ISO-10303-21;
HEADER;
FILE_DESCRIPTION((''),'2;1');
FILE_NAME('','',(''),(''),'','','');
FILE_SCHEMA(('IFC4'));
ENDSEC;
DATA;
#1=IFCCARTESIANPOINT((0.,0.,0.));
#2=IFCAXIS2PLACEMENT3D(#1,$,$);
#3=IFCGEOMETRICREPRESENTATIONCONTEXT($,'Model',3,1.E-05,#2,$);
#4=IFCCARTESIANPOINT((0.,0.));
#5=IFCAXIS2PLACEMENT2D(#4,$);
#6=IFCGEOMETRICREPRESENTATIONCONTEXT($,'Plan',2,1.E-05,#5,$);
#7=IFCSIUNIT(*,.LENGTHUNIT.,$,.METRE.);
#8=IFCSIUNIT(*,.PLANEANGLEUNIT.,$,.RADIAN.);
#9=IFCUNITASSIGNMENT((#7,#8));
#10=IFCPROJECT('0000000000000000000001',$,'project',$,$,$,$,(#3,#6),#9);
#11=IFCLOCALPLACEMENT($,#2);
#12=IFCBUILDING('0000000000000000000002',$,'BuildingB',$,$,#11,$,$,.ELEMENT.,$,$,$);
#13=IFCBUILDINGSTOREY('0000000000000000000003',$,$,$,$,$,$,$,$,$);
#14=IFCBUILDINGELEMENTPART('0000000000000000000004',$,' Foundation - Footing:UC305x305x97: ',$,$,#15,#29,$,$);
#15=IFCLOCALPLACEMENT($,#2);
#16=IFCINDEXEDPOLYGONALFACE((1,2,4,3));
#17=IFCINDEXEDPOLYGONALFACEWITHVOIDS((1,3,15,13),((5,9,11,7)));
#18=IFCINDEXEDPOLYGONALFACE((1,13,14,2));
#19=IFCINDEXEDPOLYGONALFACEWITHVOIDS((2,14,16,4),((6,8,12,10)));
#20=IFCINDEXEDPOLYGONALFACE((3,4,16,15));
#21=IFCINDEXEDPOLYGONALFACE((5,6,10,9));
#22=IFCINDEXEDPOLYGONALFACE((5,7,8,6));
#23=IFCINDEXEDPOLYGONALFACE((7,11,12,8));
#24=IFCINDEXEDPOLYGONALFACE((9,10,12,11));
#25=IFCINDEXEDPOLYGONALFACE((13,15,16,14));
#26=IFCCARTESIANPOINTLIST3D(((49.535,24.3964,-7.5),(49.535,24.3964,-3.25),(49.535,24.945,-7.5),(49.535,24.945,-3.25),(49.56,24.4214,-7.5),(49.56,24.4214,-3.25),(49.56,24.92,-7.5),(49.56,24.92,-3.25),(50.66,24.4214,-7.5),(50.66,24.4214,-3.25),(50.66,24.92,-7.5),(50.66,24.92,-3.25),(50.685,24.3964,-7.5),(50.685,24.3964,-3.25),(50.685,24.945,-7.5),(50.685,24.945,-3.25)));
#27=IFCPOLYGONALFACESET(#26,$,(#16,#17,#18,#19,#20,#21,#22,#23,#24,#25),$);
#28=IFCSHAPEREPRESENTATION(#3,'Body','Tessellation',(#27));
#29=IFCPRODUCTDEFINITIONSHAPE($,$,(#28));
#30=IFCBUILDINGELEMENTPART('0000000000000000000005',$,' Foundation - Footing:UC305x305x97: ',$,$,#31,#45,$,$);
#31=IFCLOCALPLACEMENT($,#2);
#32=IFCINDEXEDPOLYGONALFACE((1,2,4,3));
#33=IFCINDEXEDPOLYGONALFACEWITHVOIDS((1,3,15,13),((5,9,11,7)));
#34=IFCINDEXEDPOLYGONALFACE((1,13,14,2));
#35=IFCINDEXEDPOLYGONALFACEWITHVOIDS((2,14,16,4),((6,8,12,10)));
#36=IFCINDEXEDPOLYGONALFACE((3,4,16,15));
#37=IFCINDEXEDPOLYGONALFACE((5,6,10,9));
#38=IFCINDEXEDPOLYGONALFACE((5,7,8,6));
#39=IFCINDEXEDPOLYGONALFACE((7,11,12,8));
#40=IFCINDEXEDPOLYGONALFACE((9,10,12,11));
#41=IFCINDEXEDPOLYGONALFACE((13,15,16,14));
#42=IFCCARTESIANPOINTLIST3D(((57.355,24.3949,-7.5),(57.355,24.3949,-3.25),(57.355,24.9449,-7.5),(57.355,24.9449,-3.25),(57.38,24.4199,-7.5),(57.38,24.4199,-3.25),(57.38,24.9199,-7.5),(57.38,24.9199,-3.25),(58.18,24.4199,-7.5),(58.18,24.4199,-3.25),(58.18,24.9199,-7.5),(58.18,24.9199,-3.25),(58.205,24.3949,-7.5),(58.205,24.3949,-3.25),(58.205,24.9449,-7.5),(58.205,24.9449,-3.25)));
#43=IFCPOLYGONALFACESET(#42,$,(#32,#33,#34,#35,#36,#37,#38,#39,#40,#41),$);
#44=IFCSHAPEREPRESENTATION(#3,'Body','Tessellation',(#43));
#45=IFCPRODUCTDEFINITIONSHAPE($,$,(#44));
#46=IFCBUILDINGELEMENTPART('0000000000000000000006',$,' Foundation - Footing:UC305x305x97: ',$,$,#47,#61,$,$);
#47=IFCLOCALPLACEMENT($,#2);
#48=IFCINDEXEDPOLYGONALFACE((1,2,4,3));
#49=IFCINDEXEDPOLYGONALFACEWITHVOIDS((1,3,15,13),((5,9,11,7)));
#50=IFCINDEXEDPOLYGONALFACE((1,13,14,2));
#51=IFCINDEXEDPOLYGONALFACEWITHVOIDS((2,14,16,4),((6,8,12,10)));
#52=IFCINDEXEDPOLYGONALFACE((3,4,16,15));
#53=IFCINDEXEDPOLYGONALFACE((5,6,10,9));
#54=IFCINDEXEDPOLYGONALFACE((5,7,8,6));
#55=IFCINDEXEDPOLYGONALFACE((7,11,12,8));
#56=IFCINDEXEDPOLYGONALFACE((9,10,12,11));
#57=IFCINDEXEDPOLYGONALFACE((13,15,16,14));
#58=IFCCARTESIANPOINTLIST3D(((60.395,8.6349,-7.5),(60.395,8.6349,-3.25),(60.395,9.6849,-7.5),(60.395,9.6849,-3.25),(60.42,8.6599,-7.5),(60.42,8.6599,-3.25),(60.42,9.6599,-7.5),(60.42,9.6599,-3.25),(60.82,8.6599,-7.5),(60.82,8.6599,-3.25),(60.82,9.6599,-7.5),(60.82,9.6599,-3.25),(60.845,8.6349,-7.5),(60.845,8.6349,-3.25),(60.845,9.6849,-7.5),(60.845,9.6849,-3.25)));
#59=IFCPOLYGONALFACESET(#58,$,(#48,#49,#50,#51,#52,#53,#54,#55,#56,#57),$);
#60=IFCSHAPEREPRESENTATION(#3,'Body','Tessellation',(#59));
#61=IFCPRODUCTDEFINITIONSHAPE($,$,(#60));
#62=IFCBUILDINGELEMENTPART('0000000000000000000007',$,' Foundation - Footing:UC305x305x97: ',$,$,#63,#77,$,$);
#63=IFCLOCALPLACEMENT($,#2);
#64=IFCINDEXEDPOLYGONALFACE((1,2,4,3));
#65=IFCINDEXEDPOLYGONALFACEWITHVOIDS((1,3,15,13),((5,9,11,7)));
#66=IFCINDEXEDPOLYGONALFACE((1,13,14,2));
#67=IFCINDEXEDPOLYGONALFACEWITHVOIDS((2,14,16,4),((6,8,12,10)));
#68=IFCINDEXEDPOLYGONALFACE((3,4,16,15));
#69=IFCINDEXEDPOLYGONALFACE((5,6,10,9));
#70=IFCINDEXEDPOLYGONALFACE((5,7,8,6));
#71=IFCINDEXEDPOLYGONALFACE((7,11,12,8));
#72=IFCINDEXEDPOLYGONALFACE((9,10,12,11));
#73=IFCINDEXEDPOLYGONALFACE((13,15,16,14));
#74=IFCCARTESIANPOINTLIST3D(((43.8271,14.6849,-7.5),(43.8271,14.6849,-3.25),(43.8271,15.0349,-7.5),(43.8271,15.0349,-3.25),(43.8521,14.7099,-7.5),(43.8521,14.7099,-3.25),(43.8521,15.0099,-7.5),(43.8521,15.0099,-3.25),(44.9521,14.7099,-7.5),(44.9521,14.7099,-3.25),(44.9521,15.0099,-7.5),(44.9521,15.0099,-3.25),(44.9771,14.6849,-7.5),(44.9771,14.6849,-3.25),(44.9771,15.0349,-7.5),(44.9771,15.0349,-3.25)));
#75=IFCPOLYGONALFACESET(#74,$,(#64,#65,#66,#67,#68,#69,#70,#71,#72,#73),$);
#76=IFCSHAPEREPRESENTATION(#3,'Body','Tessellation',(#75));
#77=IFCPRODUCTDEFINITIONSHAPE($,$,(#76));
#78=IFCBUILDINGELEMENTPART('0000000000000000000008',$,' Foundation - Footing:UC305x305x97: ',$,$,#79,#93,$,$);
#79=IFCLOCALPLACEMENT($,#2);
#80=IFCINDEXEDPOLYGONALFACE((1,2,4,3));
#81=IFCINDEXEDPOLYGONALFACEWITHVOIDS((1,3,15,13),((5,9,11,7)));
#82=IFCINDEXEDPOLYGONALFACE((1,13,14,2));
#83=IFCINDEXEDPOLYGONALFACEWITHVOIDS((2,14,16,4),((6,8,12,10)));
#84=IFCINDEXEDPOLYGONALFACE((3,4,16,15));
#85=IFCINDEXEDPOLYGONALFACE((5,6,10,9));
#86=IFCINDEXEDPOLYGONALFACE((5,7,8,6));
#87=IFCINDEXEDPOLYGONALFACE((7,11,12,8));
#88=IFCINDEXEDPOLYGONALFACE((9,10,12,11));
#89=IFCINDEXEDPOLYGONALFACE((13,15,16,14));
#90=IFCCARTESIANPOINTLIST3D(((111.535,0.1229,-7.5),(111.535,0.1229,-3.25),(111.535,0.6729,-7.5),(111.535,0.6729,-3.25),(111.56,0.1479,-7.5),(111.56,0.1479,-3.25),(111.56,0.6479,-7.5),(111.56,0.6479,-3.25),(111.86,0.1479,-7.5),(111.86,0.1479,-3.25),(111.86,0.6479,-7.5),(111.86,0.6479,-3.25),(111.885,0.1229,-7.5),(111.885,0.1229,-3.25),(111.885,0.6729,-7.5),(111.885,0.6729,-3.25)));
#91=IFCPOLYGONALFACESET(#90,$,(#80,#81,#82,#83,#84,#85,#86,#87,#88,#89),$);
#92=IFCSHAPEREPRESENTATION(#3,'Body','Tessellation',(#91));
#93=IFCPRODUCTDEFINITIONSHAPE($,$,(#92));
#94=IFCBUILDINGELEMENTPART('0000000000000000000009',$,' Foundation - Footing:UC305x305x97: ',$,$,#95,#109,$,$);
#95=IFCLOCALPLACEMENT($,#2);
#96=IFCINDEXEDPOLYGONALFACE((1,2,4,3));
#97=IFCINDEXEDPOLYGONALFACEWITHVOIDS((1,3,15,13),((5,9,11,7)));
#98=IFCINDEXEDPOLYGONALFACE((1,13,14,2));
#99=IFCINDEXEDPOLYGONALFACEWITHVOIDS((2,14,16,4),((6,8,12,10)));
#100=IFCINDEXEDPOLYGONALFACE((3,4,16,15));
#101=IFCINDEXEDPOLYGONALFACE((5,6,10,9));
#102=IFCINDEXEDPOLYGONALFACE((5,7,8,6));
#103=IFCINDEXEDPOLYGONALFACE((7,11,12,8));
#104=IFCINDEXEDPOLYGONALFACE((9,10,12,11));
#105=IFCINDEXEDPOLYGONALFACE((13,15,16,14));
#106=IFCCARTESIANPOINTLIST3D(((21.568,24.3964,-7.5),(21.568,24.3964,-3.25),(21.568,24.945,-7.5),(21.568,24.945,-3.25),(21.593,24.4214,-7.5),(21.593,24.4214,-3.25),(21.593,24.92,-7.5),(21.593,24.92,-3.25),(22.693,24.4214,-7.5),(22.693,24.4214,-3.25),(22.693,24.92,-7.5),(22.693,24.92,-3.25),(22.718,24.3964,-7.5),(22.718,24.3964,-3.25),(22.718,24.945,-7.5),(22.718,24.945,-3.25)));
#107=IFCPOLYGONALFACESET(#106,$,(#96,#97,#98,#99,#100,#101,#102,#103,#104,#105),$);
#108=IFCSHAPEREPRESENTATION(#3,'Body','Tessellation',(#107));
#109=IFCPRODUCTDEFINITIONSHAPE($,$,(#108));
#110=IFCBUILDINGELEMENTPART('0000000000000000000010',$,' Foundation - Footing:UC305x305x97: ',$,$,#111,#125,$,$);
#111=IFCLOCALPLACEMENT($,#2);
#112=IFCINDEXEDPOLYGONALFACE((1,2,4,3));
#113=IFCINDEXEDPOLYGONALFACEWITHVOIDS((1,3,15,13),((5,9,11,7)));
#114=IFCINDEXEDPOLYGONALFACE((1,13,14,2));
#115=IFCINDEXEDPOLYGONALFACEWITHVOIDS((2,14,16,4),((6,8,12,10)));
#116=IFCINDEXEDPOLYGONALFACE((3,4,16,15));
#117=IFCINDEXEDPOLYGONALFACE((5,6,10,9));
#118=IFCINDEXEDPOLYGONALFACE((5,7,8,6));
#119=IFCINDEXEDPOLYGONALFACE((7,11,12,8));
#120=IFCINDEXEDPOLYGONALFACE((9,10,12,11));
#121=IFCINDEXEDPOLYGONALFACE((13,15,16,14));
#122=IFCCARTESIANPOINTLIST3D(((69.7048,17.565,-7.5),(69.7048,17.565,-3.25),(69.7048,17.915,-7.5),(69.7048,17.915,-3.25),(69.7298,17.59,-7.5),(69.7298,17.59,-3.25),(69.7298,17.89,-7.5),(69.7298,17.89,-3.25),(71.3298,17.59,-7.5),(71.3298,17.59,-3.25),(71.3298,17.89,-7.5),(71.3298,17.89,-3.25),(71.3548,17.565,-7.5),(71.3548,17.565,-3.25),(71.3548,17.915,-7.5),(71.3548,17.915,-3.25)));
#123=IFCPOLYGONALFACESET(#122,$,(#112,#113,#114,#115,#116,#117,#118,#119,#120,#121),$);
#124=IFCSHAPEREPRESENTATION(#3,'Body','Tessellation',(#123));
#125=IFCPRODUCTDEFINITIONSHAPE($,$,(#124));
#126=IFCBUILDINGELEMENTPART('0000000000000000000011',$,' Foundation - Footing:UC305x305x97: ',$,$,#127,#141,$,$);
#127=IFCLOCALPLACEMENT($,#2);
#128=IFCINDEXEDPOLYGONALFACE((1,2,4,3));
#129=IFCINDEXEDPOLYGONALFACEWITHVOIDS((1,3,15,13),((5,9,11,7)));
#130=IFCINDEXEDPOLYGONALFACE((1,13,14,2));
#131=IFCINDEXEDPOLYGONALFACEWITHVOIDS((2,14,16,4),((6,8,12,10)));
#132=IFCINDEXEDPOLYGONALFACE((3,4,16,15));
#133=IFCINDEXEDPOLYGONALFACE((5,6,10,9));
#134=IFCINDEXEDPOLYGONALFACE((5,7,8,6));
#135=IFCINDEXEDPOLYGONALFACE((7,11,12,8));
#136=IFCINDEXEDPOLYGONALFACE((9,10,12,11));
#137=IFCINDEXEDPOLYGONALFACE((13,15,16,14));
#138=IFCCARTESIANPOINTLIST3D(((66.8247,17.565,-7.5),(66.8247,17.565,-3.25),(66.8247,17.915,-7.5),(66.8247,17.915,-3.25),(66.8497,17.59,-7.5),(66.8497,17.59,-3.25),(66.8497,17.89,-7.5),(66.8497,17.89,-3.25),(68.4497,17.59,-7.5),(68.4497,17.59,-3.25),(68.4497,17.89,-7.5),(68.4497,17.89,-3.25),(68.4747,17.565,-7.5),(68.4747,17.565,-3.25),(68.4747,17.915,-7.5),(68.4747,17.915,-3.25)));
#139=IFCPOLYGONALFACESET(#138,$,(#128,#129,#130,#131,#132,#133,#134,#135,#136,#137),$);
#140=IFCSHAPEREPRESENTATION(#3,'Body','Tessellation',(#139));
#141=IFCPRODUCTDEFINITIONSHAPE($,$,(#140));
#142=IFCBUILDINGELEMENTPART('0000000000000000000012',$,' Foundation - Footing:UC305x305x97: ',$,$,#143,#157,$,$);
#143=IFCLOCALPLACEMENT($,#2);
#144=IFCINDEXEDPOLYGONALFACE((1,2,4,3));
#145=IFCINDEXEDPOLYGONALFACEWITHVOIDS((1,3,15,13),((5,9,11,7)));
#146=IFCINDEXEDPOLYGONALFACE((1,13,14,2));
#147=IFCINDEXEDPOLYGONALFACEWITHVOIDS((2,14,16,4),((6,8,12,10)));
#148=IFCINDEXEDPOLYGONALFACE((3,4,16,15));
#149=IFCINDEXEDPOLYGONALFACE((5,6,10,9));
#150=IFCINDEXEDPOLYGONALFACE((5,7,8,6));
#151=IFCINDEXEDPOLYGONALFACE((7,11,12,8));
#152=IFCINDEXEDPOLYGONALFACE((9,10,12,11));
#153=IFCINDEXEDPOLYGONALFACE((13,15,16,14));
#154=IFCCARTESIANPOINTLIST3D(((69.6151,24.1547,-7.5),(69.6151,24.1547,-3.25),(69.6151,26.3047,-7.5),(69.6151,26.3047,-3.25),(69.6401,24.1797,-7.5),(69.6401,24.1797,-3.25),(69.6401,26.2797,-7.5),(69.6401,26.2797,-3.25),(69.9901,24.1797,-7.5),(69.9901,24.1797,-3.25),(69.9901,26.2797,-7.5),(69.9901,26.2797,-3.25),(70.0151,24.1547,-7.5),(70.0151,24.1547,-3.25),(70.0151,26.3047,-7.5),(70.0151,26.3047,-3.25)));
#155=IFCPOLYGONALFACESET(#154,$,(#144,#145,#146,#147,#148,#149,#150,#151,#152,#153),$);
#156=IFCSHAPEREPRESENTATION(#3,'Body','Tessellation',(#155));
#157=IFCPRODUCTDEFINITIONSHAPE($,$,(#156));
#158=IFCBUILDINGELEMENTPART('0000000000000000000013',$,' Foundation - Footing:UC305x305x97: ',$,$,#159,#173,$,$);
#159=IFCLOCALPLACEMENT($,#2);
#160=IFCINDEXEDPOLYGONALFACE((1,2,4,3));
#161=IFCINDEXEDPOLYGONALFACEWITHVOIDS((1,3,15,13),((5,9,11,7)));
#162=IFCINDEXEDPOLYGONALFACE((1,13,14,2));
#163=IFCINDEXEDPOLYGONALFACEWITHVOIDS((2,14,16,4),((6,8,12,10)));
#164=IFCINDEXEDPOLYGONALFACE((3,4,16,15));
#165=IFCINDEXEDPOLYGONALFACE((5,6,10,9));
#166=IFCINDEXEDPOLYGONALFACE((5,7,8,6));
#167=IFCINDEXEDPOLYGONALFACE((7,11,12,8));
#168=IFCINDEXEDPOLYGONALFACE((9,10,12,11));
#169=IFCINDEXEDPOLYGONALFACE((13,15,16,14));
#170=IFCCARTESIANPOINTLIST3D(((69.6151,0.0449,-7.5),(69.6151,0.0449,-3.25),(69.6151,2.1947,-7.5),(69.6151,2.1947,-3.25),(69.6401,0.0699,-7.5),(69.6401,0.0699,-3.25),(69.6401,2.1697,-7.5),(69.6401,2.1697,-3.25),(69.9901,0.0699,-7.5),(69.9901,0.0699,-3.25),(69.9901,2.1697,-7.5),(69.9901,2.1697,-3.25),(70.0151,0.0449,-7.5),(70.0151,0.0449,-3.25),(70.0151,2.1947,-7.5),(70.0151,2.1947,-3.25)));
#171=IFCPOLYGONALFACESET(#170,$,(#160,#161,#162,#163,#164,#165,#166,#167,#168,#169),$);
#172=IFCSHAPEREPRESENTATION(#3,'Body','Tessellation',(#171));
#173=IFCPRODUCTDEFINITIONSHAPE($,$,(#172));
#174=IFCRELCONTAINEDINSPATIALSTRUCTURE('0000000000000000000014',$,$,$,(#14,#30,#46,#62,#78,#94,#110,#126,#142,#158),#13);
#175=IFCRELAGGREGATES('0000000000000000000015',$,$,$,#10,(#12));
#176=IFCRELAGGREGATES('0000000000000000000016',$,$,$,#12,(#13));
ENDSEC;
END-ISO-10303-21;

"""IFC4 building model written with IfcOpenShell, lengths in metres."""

from ifc_helpers import new_model, si_unit, origin, origin_2d, place, context, project, spatial, polyline, outline, extrude, element, save


model = new_model("IFC4")

# Units and contexts
model_context = context("Model", 3, precision=1e-05, world=origin())
plan_context = context("Plan", 2, precision=1e-05, world=origin_2d())
ifc_project = project(units=[si_unit("LENGTHUNIT", "METRE"), si_unit("PLANEANGLEUNIT", "RADIAN")], contexts=[model_context, plan_context])

# Building, storey
building_placement = place(None, origin())
building = spatial("IfcBuilding", under=ifc_project, at=building_placement, Name="BuildingB", CompositionType="ELEMENT")
storey = spatial("IfcBuildingStorey", under=building)

# Building element parts, openings
building_element_part_1 = element("IfcBuildingElementPart", 1, inside=storey, Name=" Foundation - Footing:UC305x305x97: ", context=model_context, shape_type="SweptSolid", body=[
    extrude(outline(polyline([(50.685, 24.3964, -7.5), (49.535, 24.3964, -7.5), (49.535, 24.945, -7.5), (50.685, 24.945, -7.5), (50.685, 24.3964, -7.5)])), None, (0.0, 0.0, 1.0), 4.25),
])
element("IfcOpeningElement", 2, inside=storey, cuts=building_element_part_1, context=model_context, shape_type="SweptSolid", body=[
    extrude(outline(polyline([(50.66, 24.4214, -7.5), (49.56, 24.4214, -7.5), (49.56, 24.92, -7.5), (50.66, 24.92, -7.5), (50.66, 24.4214, -7.5)])), None, (0.0, 0.0, 1.0), 4.25),
])
building_element_part_2 = element("IfcBuildingElementPart", 3, inside=storey, Name=" Foundation - Footing:UC305x305x97: ", context=model_context, shape_type="SweptSolid", body=[
    extrude(outline(polyline([(57.355, 24.3949, -7.5), (58.205, 24.3949, -7.5), (58.205, 24.9449, -7.5), (57.355, 24.9449, -7.5), (57.355, 24.3949, -7.5)])), None, (0.0, 0.0, 1.0), 4.25),
])
element("IfcOpeningElement", 4, inside=storey, cuts=building_element_part_2, context=model_context, shape_type="SweptSolid", body=[
    extrude(outline(polyline([(57.38, 24.4199, -7.5), (58.18, 24.4199, -7.5), (58.18, 24.9199, -7.5), (57.38, 24.9199, -7.5), (57.38, 24.4199, -7.5)])), None, (0.0, 0.0, 1.0), 4.25),
])
building_element_part_3 = element("IfcBuildingElementPart", 5, inside=storey, Name=" Foundation - Footing:UC305x305x97: ", context=model_context, shape_type="SweptSolid", body=[
    extrude(outline(polyline([(60.395, 8.6349, -7.5), (60.845, 8.6349, -7.5), (60.845, 9.6849, -7.5), (60.395, 9.6849, -7.5), (60.395, 8.6349, -7.5)])), None, (0.0, 0.0, 1.0), 4.25),
])
element("IfcOpeningElement", 6, inside=storey, cuts=building_element_part_3, context=model_context, shape_type="SweptSolid", body=[
    extrude(outline(polyline([(60.42, 8.6599, -7.5), (60.82, 8.6599, -7.5), (60.82, 9.6599, -7.5), (60.42, 9.6599, -7.5), (60.42, 8.6599, -7.5)])), None, (0.0, 0.0, 1.0), 4.25),
])
building_element_part_4 = element("IfcBuildingElementPart", 7, inside=storey, Name=" Foundation - Footing:UC305x305x97: ", context=model_context, shape_type="SweptSolid", body=[
    extrude(outline(polyline([(44.9771, 14.6849, -7.5), (44.9771, 15.0349, -7.5), (43.8271, 15.0349, -7.5), (43.8271, 14.6849, -7.5), (44.9771, 14.6849, -7.5)])), None, (0.0, 0.0, 1.0), 4.25),
])
element("IfcOpeningElement", 8, inside=storey, cuts=building_element_part_4, context=model_context, shape_type="SweptSolid", body=[
    extrude(outline(polyline([(44.9521, 14.7099, -7.5), (44.9521, 15.0099, -7.5), (43.8521, 15.0099, -7.5), (43.8521, 14.7099, -7.5), (44.9521, 14.7099, -7.5)])), None, (0.0, 0.0, 1.0), 4.25),
])
building_element_part_5 = element("IfcBuildingElementPart", 9, inside=storey, Name=" Foundation - Footing:UC305x305x97: ", context=model_context, shape_type="SweptSolid", body=[
    extrude(outline(polyline([(111.535, 0.6729, -7.5), (111.885, 0.6729, -7.5), (111.885, 0.1229, -7.5), (111.535, 0.1229, -7.5), (111.535, 0.6729, -7.5)])), None, (0.0, 0.0, 1.0), 4.25),
])
element("IfcOpeningElement", 10, inside=storey, cuts=building_element_part_5, context=model_context, shape_type="SweptSolid", body=[
    extrude(outline(polyline([(111.56, 0.6479, -7.5), (111.86, 0.6479, -7.5), (111.86, 0.1479, -7.5), (111.56, 0.1479, -7.5), (111.56, 0.6479, -7.5)])), None, (0.0, 0.0, 1.0), 4.25),
])
building_element_part_6 = element("IfcBuildingElementPart", 11, inside=storey, Name=" Foundation - Footing:UC305x305x97: ", context=model_context, shape_type="SweptSolid", body=[
    extrude(outline(polyline([(21.568, 24.3964, -7.5), (22.718, 24.3964, -7.5), (22.718, 24.945, -7.5), (21.568, 24.945, -7.5), (21.568, 24.3964, -7.5)])), None, (0.0, 0.0, 1.0), 4.25),
])
element("IfcOpeningElement", 12, inside=storey, cuts=building_element_part_6, context=model_context, shape_type="SweptSolid", body=[
    extrude(outline(polyline([(21.593, 24.4214, -7.5), (22.693, 24.4214, -7.5), (22.693, 24.92, -7.5), (21.593, 24.92, -7.5), (21.593, 24.4214, -7.5)])), None, (0.0, 0.0, 1.0), 4.25),
])
building_element_part_7 = element("IfcBuildingElementPart", 13, inside=storey, Name=" Foundation - Footing:UC305x305x97: ", context=model_context, shape_type="SweptSolid", body=[
    extrude(outline(polyline([(69.7048, 17.565, -7.5), (69.7048, 17.915, -7.5), (71.3548, 17.915, -7.5), (71.3548, 17.565, -7.5), (69.7048, 17.565, -7.5)])), None, (0.0, 0.0, 1.0), 4.25),
])
element("IfcOpeningElement", 14, inside=storey, cuts=building_element_part_7, context=model_context, shape_type="SweptSolid", body=[
    extrude(outline(polyline([(69.7298, 17.59, -7.5), (69.7298, 17.89, -7.5), (71.3298, 17.89, -7.5), (71.3298, 17.59, -7.5), (69.7298, 17.59, -7.5)])), None, (0.0, 0.0, 1.0), 4.25),
])
building_element_part_8 = element("IfcBuildingElementPart", 15, inside=storey, Name=" Foundation - Footing:UC305x305x97: ", context=model_context, shape_type="SweptSolid", body=[
    extrude(outline(polyline([(66.8247, 17.565, -7.5), (66.8247, 17.915, -7.5), (68.4747, 17.915, -7.5), (68.4747, 17.565, -7.5), (66.8247, 17.565, -7.5)])), None, (0.0, 0.0, 1.0), 4.25),
])
element("IfcOpeningElement", 16, inside=storey, cuts=building_element_part_8, context=model_context, shape_type="SweptSolid", body=[
    extrude(outline(polyline([(66.8497, 17.59, -7.5), (66.8497, 17.89, -7.5), (68.4497, 17.89, -7.5), (68.4497, 17.59, -7.5), (66.8497, 17.59, -7.5)])), None, (0.0, 0.0, 1.0), 4.25),
])
building_element_part_9 = element("IfcBuildingElementPart", 17, inside=storey, Name=" Foundation - Footing:UC305x305x97: ", context=model_context, shape_type="SweptSolid", body=[
    extrude(outline(polyline([(70.0151, 26.3047, -7.5), (69.6151, 26.3047, -7.5), (69.6151, 24.1547, -7.5), (70.0151, 24.1547, -7.5), (70.0151, 26.3047, -7.5)])), None, (0.0, 0.0, 1.0), 4.25),
])
element("IfcOpeningElement", 18, inside=storey, cuts=building_element_part_9, context=model_context, shape_type="SweptSolid", body=[
    extrude(outline(polyline([(69.9901, 26.2797, -7.5), (69.6401, 26.2797, -7.5), (69.6401, 24.1797, -7.5), (69.9901, 24.1797, -7.5), (69.9901, 26.2797, -7.5)])), None, (0.0, 0.0, 1.0), 4.25),
])
building_element_part_10 = element("IfcBuildingElementPart", 19, inside=storey, Name=" Foundation - Footing:UC305x305x97: ", context=model_context, shape_type="SweptSolid", body=[
    extrude(outline(polyline([(70.0151, 2.1947, -7.5), (69.6151, 2.1947, -7.5), (69.6151, 0.0449, -7.5), (70.0151, 0.0449, -7.5), (70.0151, 2.1947, -7.5)])), None, (0.0, 0.0, 1.0), 4.25),
])
element("IfcOpeningElement", 20, inside=storey, cuts=building_element_part_10, context=model_context, shape_type="SweptSolid", body=[
    extrude(outline(polyline([(69.9901, 2.1697, -7.5), (69.6401, 2.1697, -7.5), (69.6401, 0.0699, -7.5), (69.9901, 0.0699, -7.5), (69.9901, 2.1697, -7.5)])), None, (0.0, 0.0, 1.0), 4.25),
])

save(model, "model.ifc")
